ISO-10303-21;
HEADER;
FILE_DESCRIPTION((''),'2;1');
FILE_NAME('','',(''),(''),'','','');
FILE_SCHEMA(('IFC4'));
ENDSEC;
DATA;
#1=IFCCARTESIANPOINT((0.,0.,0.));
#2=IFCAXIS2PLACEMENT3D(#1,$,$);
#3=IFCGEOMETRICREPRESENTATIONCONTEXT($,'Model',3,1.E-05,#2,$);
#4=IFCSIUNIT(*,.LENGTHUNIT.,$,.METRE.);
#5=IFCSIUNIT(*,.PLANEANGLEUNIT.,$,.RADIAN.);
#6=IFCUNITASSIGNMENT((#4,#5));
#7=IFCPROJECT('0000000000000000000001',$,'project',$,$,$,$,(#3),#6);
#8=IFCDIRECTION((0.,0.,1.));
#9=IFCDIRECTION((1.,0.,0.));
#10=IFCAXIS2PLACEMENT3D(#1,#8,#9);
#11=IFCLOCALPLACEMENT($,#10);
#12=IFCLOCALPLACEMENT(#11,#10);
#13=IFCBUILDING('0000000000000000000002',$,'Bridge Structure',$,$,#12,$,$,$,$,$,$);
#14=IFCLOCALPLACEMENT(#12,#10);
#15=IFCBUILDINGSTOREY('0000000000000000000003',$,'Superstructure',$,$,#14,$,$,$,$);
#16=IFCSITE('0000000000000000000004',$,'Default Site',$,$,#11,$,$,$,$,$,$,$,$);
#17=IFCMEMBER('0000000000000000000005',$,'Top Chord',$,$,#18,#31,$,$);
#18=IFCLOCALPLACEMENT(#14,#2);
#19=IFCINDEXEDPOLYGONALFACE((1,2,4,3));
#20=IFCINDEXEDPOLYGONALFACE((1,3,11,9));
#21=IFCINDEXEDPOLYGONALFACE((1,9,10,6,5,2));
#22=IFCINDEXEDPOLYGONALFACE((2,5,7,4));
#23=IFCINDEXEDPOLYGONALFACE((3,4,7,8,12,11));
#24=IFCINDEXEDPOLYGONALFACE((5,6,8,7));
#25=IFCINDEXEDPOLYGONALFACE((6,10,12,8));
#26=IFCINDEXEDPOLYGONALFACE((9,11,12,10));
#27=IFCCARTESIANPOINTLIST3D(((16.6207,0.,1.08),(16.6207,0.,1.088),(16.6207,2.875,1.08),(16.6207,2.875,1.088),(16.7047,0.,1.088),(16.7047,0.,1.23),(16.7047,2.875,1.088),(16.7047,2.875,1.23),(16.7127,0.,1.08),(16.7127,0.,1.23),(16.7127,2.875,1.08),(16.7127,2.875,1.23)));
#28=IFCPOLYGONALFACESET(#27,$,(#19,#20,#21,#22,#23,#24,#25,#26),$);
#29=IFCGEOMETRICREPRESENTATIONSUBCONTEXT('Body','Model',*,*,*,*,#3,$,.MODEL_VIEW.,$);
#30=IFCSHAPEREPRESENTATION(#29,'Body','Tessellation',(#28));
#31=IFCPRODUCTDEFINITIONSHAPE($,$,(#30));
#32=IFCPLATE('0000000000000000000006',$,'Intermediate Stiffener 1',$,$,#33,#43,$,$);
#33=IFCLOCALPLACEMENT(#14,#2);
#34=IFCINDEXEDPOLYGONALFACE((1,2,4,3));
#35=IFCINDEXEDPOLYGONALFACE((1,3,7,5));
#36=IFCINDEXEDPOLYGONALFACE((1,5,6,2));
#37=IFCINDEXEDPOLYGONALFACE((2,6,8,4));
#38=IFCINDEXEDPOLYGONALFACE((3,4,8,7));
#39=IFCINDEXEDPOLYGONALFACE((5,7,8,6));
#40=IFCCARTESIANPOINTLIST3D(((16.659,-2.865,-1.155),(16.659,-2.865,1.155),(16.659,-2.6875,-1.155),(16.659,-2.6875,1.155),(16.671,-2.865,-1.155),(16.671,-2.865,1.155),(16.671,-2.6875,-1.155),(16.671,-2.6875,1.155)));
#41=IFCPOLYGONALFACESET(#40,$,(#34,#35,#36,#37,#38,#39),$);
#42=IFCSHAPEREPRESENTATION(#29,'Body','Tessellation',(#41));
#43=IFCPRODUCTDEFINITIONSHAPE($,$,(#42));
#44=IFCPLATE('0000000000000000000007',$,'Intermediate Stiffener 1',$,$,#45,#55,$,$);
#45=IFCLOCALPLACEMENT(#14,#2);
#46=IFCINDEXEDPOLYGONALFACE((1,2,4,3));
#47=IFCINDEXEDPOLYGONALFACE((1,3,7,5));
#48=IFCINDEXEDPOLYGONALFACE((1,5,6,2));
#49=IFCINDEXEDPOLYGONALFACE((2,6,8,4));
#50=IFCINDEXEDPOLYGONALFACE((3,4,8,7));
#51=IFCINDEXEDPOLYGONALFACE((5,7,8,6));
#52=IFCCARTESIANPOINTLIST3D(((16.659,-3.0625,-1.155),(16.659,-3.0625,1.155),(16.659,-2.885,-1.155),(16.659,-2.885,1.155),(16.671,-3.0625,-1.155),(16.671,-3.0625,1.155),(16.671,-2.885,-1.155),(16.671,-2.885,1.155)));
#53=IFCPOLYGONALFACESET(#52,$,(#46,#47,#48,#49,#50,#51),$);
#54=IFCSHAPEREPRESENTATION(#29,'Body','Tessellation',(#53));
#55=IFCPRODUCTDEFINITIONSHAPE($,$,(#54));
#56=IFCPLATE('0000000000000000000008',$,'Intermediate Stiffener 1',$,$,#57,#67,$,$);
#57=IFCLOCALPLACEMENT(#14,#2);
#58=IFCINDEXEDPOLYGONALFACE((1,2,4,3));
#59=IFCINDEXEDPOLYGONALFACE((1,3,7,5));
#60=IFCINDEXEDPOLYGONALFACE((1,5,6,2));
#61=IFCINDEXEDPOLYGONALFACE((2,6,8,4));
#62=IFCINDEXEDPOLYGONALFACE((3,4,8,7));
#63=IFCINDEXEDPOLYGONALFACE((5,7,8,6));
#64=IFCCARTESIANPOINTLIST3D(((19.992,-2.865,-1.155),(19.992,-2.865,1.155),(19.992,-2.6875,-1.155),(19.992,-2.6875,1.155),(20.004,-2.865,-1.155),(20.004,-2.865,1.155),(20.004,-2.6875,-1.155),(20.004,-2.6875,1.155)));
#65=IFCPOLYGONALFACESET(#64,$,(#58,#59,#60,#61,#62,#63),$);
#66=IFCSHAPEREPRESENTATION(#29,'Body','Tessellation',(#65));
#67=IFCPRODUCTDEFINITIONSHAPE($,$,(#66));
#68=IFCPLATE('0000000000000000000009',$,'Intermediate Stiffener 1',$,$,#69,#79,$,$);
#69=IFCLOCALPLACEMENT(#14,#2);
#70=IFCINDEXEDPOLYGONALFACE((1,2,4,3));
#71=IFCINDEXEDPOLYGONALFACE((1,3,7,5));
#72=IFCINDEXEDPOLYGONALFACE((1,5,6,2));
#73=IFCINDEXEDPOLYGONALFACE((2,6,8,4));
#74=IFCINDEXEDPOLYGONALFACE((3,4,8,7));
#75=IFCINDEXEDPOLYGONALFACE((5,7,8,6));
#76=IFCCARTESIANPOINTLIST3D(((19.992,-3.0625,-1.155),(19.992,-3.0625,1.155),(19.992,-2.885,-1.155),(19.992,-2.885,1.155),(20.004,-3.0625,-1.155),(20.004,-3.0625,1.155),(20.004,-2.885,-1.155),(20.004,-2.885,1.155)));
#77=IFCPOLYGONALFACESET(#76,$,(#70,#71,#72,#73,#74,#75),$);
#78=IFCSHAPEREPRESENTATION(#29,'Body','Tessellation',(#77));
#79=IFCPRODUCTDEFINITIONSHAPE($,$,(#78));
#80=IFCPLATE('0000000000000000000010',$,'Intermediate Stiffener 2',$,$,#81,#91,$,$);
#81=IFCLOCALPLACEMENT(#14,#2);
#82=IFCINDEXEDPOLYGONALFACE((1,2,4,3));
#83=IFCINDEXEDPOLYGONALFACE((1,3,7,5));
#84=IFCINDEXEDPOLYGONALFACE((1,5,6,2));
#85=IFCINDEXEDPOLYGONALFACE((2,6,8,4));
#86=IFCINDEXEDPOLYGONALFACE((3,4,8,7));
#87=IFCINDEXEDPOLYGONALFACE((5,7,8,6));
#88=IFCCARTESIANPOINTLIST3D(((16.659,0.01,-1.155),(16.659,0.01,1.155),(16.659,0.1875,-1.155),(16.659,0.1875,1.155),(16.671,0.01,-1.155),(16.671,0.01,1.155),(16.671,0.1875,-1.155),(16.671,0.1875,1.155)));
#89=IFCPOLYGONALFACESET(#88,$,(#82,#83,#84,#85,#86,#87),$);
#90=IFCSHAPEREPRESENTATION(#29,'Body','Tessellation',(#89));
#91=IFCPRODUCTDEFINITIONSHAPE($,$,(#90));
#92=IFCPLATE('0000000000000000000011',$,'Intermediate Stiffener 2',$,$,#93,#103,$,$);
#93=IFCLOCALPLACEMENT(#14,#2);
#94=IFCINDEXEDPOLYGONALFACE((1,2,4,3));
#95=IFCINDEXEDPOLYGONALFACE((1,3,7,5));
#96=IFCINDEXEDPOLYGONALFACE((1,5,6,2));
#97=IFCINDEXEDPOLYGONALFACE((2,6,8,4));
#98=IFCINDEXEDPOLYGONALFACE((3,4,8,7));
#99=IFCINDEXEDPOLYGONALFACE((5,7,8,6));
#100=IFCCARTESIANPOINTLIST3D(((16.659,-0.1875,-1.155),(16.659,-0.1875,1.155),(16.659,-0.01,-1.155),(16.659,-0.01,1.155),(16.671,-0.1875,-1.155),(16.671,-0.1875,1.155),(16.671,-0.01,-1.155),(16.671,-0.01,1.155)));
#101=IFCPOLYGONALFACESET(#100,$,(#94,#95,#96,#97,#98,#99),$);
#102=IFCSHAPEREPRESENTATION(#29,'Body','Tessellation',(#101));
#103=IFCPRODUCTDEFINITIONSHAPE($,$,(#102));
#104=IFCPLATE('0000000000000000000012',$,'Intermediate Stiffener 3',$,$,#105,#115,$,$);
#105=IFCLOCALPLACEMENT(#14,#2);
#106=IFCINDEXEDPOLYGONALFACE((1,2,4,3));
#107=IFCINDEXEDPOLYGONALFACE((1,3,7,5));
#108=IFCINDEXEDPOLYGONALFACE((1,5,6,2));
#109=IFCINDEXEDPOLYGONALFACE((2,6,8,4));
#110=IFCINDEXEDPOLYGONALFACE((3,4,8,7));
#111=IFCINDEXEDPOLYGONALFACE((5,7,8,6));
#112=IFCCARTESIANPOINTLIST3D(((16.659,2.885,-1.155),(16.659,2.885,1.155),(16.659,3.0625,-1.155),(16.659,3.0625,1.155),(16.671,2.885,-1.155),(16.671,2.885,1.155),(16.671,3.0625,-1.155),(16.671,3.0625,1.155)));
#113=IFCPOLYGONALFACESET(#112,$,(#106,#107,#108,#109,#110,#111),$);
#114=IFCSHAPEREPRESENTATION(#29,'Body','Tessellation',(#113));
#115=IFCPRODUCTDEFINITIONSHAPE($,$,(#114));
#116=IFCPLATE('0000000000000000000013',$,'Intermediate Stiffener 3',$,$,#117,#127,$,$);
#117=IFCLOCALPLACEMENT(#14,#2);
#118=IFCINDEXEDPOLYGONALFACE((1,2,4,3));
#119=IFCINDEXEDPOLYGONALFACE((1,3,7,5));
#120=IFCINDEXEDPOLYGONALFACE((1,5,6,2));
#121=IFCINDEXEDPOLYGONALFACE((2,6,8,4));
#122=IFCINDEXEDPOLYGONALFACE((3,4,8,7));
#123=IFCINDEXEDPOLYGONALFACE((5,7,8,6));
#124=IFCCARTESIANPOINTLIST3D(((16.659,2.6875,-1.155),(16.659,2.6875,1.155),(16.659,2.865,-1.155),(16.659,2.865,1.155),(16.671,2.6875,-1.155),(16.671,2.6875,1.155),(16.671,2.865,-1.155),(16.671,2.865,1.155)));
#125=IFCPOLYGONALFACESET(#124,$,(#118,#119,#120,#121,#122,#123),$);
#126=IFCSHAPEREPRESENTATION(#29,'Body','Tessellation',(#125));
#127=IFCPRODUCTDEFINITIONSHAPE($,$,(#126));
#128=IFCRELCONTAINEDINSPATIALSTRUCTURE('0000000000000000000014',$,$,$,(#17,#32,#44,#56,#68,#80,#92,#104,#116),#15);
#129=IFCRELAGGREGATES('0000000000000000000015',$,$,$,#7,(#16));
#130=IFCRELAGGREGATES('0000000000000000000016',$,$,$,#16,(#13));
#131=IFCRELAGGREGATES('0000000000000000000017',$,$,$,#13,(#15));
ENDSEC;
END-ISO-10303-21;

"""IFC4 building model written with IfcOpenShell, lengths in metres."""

from ifc_helpers import new_model, si_unit, frame, origin, origin_with_axes, origin_2d_with_axis, place, context, subcontext, project, spatial, rectangle, l_section, extrude, element, save


model = new_model("IFC4")

# Units and contexts
model_context = context("Model", 3, precision=1e-05, world=origin())
body_context = subcontext(model_context, "Body", "Model", "MODEL_VIEW")
ifc_project = project(units=[si_unit("LENGTHUNIT", "METRE"), si_unit("PLANEANGLEUNIT", "RADIAN")], contexts=[model_context])

# Site, building, storey
site_placement = place(None, origin_with_axes())
site = spatial("IfcSite", under=ifc_project, at=site_placement, Name="Default Site")
building_placement = place(site_placement, origin_with_axes())
building = spatial("IfcBuilding", under=site, at=building_placement, Name="Bridge Structure")
storey_placement = place(building_placement, origin_with_axes())
storey = spatial("IfcBuildingStorey", under=building, at=storey_placement, Name="Superstructure")

# Member
for number, where, z_axis, x_axis, name in (
    (1, (16.6667, 0.0, 1.155), (0.0, 1.0, 0.0), (-1.0, 0.0, 0.0), "Top Chord"),
):
    element("IfcMember", number, at=place(storey_placement, frame(where, z_axis=z_axis, x_axis=x_axis)), inside=storey, Name=name, context=body_context, shape_type="SweptSolid", body=[
        extrude(l_section(Depth=0.15, Width=0.092, Thickness=0.008, at=origin_2d_with_axis()), origin_with_axes(), (0.0, 0.0, 1.0), 2.875),
    ])

# Plates
for number, where, z_axis, x_axis, name in (
    (2, (16.665, -2.7763, -1.155), (0.0, 0.0, 1.0), (1.0, 0.0, 0.0), "Intermediate Stiffener 1"),
    (3, (16.665, -2.9737, -1.155), (0.0, 0.0, 1.0), (1.0, 0.0, 0.0), "Intermediate Stiffener 1"),
    (4, (19.998, -2.7763, -1.155), (0.0, 0.0, 1.0), (1.0, 0.0, 0.0), "Intermediate Stiffener 1"),
    (5, (19.998, -2.9737, -1.155), (0.0, 0.0, 1.0), (1.0, 0.0, 0.0), "Intermediate Stiffener 1"),
    (6, (16.665, 0.0988, -1.155), (0.0, 0.0, 1.0), (1.0, 0.0, 0.0), "Intermediate Stiffener 2"),
    (7, (16.665, -0.0988, -1.155), (0.0, 0.0, 1.0), (1.0, 0.0, 0.0), "Intermediate Stiffener 2"),
    (8, (16.665, 2.9737, -1.155), (0.0, 0.0, 1.0), (1.0, 0.0, 0.0), "Intermediate Stiffener 3"),
    (9, (16.665, 2.7763, -1.155), (0.0, 0.0, 1.0), (1.0, 0.0, 0.0), "Intermediate Stiffener 3"),
):
    element("IfcPlate", number, at=place(storey_placement, frame(where, z_axis=z_axis, x_axis=x_axis)), inside=storey, Name=name, context=body_context, shape_type="SweptSolid", body=[
        extrude(rectangle(XDim=0.012, YDim=0.1775, at=origin_2d_with_axis()), origin_with_axes(), (0.0, 0.0, 1.0), 2.31),
    ])

save(model, "model.ifc")
